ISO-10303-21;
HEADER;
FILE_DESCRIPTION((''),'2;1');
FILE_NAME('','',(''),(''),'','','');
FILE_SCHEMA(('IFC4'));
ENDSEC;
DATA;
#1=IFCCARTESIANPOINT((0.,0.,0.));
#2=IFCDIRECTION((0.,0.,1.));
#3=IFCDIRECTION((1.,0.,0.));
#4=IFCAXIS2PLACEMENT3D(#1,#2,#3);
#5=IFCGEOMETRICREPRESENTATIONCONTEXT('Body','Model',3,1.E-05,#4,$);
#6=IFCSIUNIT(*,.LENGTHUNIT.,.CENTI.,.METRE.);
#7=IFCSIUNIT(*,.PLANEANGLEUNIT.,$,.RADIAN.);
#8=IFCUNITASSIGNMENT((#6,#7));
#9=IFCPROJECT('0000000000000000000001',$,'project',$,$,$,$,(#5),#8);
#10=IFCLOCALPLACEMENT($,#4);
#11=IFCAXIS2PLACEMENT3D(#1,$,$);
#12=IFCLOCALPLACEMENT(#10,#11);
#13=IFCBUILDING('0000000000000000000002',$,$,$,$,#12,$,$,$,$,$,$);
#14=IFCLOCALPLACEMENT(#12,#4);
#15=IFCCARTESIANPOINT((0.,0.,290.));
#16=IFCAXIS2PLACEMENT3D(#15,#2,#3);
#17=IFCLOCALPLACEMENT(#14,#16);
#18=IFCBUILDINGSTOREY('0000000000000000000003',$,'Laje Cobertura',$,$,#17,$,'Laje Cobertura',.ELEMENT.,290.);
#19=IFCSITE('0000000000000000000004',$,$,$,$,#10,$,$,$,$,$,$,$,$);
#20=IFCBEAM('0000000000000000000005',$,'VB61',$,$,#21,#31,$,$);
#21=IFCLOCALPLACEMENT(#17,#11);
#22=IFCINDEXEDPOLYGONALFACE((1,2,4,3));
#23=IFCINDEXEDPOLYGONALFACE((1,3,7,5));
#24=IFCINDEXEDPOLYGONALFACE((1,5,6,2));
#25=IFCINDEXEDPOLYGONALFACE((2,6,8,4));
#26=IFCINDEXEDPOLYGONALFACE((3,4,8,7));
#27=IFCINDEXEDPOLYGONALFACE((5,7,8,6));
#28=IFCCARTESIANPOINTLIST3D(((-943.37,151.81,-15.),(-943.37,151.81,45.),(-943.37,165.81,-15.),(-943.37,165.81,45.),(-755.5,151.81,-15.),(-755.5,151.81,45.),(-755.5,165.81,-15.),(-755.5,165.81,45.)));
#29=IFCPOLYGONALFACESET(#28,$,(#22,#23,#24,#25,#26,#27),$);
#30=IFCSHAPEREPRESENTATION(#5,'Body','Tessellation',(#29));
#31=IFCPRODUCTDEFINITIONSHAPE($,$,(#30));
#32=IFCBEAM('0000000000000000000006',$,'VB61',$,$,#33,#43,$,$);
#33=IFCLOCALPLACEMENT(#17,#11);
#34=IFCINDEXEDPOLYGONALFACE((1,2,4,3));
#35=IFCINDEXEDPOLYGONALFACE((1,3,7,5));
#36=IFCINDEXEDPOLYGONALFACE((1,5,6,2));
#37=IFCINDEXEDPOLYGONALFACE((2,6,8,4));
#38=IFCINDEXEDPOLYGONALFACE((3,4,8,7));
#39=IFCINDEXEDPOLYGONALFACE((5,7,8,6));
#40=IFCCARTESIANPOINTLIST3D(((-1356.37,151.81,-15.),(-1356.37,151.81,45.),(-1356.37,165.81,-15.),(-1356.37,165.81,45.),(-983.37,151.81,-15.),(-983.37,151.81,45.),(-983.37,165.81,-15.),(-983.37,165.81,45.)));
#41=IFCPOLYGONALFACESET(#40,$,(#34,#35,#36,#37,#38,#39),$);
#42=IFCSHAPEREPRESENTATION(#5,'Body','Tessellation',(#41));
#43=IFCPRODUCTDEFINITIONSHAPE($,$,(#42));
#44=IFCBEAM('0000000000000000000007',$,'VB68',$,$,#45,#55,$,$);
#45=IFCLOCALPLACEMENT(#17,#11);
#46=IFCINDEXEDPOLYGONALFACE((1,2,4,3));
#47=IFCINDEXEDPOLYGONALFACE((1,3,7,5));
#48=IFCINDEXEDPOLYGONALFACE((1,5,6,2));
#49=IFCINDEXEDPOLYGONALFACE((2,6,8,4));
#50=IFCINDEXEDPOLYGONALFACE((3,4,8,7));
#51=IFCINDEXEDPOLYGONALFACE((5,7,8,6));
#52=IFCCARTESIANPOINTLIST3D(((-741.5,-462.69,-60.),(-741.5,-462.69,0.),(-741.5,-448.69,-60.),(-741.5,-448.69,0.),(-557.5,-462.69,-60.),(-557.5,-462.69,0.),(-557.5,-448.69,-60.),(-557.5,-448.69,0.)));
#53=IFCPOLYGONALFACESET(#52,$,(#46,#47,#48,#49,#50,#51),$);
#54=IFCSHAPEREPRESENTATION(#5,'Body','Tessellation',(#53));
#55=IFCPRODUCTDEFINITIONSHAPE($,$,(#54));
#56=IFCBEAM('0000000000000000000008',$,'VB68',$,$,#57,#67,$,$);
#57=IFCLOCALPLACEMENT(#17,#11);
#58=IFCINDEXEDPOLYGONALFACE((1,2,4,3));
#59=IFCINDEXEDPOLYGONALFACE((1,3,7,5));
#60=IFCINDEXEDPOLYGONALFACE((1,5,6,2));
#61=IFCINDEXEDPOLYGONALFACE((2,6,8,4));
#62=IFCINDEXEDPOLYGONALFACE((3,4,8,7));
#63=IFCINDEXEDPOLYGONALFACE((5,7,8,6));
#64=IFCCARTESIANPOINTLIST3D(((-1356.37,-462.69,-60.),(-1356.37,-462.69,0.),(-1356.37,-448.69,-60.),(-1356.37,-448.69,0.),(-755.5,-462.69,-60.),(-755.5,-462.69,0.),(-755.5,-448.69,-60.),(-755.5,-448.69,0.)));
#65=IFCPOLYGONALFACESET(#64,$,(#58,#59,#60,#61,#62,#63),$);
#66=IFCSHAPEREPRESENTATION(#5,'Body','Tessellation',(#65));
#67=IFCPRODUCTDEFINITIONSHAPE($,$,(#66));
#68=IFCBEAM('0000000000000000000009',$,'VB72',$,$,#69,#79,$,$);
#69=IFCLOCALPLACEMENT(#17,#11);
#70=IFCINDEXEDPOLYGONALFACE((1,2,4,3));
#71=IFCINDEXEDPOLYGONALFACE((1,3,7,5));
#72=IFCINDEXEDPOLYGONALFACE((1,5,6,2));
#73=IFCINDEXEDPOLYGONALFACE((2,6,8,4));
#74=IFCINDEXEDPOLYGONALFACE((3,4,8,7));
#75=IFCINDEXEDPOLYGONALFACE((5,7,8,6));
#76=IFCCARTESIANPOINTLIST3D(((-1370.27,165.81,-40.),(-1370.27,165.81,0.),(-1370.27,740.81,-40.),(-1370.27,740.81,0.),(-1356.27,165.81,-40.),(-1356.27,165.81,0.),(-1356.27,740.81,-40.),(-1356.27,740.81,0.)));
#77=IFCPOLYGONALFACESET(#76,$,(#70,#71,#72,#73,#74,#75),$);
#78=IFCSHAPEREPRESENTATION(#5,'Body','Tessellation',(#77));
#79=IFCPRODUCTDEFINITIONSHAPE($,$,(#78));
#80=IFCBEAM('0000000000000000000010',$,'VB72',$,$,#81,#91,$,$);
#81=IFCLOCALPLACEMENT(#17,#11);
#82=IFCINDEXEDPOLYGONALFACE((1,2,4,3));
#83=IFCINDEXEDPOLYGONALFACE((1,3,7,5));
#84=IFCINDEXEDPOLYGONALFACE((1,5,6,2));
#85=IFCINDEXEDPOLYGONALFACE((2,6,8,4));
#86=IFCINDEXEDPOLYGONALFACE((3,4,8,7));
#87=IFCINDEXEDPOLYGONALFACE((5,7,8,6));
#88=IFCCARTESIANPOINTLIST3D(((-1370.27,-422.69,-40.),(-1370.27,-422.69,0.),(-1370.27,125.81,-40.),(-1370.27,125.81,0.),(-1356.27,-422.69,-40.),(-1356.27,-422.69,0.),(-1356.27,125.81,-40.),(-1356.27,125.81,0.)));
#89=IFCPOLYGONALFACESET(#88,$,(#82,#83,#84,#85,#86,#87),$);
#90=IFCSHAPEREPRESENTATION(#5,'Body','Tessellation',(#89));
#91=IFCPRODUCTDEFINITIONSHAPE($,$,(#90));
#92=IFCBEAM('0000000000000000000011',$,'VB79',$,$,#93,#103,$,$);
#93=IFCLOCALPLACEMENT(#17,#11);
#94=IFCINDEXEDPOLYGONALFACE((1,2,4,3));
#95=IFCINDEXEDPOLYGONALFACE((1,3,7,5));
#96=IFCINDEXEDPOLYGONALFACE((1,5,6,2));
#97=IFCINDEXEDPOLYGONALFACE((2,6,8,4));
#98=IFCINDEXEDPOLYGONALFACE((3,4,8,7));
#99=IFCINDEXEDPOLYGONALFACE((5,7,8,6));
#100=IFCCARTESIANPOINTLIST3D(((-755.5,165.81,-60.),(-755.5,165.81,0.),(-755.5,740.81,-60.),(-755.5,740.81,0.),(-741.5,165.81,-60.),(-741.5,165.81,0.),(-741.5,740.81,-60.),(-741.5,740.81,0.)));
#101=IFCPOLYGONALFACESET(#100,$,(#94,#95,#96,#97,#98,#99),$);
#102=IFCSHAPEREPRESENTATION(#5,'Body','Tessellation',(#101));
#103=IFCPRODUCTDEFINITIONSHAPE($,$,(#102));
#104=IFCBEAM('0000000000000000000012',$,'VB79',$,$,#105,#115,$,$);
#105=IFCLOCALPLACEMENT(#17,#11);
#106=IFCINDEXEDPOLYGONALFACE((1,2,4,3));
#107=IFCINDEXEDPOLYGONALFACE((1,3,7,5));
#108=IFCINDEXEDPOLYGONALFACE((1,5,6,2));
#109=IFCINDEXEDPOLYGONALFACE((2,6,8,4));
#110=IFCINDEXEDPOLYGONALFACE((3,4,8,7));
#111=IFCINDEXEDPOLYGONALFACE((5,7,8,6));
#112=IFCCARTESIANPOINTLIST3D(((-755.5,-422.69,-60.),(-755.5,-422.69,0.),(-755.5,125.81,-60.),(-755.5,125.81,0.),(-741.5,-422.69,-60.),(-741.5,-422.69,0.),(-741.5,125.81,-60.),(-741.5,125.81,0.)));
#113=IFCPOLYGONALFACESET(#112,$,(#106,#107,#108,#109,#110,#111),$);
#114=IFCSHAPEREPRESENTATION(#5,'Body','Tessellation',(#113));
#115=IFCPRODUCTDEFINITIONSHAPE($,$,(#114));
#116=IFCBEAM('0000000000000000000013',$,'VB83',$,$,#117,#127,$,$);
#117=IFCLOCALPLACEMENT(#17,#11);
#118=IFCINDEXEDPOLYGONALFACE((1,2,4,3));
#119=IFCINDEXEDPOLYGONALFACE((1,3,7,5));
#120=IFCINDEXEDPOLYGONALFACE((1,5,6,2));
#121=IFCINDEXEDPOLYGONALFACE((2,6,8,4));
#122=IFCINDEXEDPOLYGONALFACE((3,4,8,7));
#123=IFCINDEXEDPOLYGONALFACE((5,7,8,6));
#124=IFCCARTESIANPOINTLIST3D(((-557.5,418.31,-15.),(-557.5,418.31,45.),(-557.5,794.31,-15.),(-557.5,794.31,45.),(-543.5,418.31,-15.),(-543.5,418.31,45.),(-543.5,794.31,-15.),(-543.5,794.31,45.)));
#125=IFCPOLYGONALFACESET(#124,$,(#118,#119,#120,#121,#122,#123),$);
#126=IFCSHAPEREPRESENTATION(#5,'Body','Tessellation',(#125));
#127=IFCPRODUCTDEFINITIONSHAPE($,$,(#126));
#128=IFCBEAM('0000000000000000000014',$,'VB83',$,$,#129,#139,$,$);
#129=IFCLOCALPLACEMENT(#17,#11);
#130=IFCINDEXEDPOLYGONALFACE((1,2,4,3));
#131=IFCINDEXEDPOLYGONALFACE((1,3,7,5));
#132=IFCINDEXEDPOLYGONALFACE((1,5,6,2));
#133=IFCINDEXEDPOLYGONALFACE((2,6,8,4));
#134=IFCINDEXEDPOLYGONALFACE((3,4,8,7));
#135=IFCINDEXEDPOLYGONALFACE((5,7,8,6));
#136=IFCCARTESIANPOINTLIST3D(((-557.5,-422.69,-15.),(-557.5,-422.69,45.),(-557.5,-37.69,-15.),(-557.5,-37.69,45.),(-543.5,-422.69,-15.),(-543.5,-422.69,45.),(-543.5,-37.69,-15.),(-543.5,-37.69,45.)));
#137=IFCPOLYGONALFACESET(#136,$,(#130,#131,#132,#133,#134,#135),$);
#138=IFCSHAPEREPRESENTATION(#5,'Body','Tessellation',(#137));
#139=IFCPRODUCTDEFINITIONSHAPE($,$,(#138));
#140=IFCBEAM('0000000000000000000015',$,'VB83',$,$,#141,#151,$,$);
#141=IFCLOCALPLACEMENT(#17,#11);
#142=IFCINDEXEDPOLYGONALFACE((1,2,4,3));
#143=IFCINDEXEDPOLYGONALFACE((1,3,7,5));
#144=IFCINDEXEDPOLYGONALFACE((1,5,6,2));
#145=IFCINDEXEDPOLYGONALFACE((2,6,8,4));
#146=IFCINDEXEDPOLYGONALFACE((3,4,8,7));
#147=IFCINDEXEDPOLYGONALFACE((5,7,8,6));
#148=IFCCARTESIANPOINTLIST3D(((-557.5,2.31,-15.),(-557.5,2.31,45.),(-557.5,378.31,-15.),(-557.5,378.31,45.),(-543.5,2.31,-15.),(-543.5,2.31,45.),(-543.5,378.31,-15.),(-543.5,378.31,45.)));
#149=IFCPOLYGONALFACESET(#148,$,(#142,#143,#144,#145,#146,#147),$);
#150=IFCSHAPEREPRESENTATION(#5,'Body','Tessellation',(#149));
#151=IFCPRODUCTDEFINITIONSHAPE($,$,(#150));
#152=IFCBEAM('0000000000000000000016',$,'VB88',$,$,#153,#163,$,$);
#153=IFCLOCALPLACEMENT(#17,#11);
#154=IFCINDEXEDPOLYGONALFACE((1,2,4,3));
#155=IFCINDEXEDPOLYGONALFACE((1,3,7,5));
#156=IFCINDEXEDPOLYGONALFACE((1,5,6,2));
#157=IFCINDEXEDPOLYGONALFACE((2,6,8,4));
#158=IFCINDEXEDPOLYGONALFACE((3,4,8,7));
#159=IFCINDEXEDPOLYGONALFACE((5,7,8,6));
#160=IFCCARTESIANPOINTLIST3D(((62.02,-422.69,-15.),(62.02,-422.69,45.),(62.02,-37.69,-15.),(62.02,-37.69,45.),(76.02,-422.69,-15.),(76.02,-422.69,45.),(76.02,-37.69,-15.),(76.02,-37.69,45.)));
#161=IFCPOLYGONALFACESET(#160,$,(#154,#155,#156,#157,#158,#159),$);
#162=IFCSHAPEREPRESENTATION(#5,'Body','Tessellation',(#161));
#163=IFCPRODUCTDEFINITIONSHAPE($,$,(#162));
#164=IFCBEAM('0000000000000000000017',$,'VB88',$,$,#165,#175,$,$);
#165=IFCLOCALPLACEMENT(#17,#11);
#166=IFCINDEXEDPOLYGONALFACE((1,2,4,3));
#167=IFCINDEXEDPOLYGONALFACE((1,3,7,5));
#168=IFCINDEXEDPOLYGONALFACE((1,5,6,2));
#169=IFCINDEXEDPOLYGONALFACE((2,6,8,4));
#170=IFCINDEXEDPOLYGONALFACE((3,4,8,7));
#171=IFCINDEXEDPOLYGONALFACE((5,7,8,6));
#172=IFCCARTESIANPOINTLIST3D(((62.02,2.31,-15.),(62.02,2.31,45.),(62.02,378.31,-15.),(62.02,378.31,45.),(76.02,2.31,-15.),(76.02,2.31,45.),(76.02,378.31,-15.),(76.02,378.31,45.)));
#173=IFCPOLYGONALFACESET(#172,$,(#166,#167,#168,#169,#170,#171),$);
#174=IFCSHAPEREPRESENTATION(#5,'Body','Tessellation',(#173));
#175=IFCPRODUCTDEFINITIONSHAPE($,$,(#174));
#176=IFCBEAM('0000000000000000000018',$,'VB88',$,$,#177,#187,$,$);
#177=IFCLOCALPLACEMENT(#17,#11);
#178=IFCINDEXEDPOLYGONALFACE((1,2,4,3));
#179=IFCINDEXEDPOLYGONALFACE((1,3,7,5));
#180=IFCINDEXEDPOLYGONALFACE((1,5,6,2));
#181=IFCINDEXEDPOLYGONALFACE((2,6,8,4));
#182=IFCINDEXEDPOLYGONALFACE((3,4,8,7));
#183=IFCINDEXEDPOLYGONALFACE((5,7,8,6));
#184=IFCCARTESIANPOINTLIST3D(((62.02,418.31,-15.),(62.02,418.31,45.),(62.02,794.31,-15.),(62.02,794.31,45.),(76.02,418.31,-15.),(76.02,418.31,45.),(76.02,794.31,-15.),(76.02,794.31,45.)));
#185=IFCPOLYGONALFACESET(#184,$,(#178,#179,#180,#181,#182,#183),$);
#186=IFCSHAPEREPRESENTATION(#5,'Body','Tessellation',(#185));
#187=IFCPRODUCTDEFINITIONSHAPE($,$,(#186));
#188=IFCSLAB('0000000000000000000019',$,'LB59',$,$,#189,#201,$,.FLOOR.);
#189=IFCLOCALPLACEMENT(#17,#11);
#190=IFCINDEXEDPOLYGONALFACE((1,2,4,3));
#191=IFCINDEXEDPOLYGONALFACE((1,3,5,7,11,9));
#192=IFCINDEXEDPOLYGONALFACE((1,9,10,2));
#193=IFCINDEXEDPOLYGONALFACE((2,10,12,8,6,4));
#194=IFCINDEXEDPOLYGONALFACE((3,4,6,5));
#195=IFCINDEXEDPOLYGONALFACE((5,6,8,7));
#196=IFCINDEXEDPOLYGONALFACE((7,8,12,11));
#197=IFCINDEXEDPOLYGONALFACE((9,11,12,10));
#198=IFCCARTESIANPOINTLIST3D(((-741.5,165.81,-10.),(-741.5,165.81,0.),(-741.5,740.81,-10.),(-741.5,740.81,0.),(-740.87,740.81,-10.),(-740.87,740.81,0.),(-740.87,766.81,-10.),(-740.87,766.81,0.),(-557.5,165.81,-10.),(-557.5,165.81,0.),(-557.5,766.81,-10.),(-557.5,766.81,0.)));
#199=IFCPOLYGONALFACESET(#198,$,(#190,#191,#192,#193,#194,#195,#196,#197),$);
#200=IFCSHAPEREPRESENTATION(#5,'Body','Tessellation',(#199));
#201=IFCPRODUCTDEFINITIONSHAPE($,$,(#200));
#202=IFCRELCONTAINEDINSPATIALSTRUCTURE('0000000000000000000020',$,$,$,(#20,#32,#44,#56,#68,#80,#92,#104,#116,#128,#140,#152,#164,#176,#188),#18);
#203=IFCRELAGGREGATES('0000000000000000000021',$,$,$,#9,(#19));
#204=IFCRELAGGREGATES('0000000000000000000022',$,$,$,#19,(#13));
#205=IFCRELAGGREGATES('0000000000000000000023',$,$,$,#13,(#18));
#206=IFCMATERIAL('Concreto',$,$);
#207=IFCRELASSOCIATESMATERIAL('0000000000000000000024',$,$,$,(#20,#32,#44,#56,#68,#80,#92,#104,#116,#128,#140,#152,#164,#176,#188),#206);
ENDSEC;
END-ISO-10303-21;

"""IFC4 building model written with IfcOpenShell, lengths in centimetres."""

from ifc_helpers import new_model, si_unit, frame, origin, origin_with_axes, origin_2d_with_axis, place, context, project, spatial, polyline, rectangle, outline, extrude, material, element, save


model = new_model("IFC4")

# Units and contexts
model_context = context("Model", 3, precision=1e-05, world=origin_with_axes(), identifier="Body")
ifc_project = project(units=[si_unit("LENGTHUNIT", "METRE", prefix="CENTI"), si_unit("PLANEANGLEUNIT", "RADIAN")], contexts=[model_context])

# Site, building, storey
site_placement = place(None, origin_with_axes())
site = spatial("IfcSite", under=ifc_project, at=site_placement)
building_placement = place(site_placement, origin())
building = spatial("IfcBuilding", under=site, at=building_placement)
placement = place(building_placement, origin_with_axes())
storey_placement = place(placement, frame((0.0, 0.0, 290.0), z_axis=(0.0, 0.0, 1.0), x_axis=(1.0, 0.0, 0.0)))
storey = spatial("IfcBuildingStorey", under=building, at=storey_placement, Name="Laje Cobertura", LongName="Laje Cobertura", CompositionType="ELEMENT", Elevation=290.0)

# Shared definitions
ifc_material = material(Name="Concreto")

# Beams
beam_1_placement = place(storey_placement, frame((-849.43, 158.81, 45.0), z_axis=(0.0, 0.0, 1.0), x_axis=(1.0, 0.0, 0.0)))
element("IfcBeam", 1, at=beam_1_placement, inside=storey, material=ifc_material, Name="VB61", context=model_context, shape_type="SolidModel", body=[
    extrude(rectangle(XDim=14.0, YDim=60.0, at=origin_2d_with_axis()), frame((-93.94, 0.0, -30.0), z_axis=(1.0, 0.0, 0.0), x_axis=(0.0, -1.0, 0.0)), (0.0, 0.0, 1.0), 187.87),
])
beam_2_placement = place(storey_placement, frame((-1169.87, 158.81, 45.0), z_axis=(0.0, 0.0, 1.0), x_axis=(1.0, 0.0, 0.0)))
element("IfcBeam", 2, at=beam_2_placement, inside=storey, material=ifc_material, Name="VB61", context=model_context, shape_type="SolidModel", body=[
    extrude(rectangle(XDim=14.0, YDim=60.0, at=origin_2d_with_axis()), frame((-186.5, 0.0, -30.0), z_axis=(1.0, 0.0, 0.0), x_axis=(0.0, -1.0, 0.0)), (0.0, 0.0, 1.0), 373.0),
])
beam_3_placement = place(storey_placement, frame((-649.5, -455.69, 0.0), z_axis=(0.0, 0.0, 1.0), x_axis=(1.0, 0.0, 0.0)))
element("IfcBeam", 3, at=beam_3_placement, inside=storey, material=ifc_material, Name="VB68", context=model_context, shape_type="SolidModel", body=[
    extrude(rectangle(XDim=14.0, YDim=60.0, at=origin_2d_with_axis()), frame((-92.0, 0.0, -30.0), z_axis=(1.0, 0.0, 0.0), x_axis=(0.0, -1.0, 0.0)), (0.0, 0.0, 1.0), 184.0),
])
beam_4_placement = place(storey_placement, frame((-1055.93, -455.69, 0.0), z_axis=(0.0, 0.0, 1.0), x_axis=(1.0, 0.0, 0.0)))
element("IfcBeam", 4, at=beam_4_placement, inside=storey, material=ifc_material, Name="VB68", context=model_context, shape_type="SolidModel", body=[
    extrude(rectangle(XDim=14.0, YDim=60.0, at=origin_2d_with_axis()), frame((-300.44, 0.0, -30.0), z_axis=(1.0, 0.0, 0.0), x_axis=(0.0, -1.0, 0.0)), (0.0, 0.0, 1.0), 600.87),
])
beam_5_placement = place(storey_placement, frame((-1363.27, 453.31, 0.0), z_axis=(0.0, 0.0, 1.0), x_axis=(1.0, 0.0, 0.0)))
element("IfcBeam", 5, at=beam_5_placement, inside=storey, material=ifc_material, Name="VB72", context=model_context, shape_type="SolidModel", body=[
    extrude(rectangle(XDim=14.0, YDim=40.0, at=origin_2d_with_axis()), frame((0.0, -287.5, -20.0), z_axis=(0.0, 1.0, 0.0), x_axis=(-1.0, 0.0, 0.0)), (0.0, 0.0, 1.0), 575.0),
])
beam_6_placement = place(storey_placement, frame((-1363.27, -148.44, 0.0), z_axis=(0.0, 0.0, 1.0), x_axis=(1.0, 0.0, 0.0)))
element("IfcBeam", 6, at=beam_6_placement, inside=storey, material=ifc_material, Name="VB72", context=model_context, shape_type="SolidModel", body=[
    extrude(rectangle(XDim=14.0, YDim=40.0, at=origin_2d_with_axis()), frame((0.0, -274.25, -20.0), z_axis=(0.0, 1.0, 0.0), x_axis=(-1.0, 0.0, 0.0)), (0.0, 0.0, 1.0), 548.5),
])
beam_7_placement = place(storey_placement, frame((-748.5, 453.31, 0.0), z_axis=(0.0, 0.0, 1.0), x_axis=(1.0, 0.0, 0.0)))
element("IfcBeam", 7, at=beam_7_placement, inside=storey, material=ifc_material, Name="VB79", context=model_context, shape_type="SolidModel", body=[
    extrude(rectangle(XDim=14.0, YDim=60.0, at=origin_2d_with_axis()), frame((0.0, -287.5, -30.0), z_axis=(0.0, 1.0, 0.0), x_axis=(-1.0, 0.0, 0.0)), (0.0, 0.0, 1.0), 575.0),
])
beam_8_placement = place(storey_placement, frame((-748.5, -148.44, 0.0), z_axis=(0.0, 0.0, 1.0), x_axis=(1.0, 0.0, 0.0)))
element("IfcBeam", 8, at=beam_8_placement, inside=storey, material=ifc_material, Name="VB79", context=model_context, shape_type="SolidModel", body=[
    extrude(rectangle(XDim=14.0, YDim=60.0, at=origin_2d_with_axis()), frame((0.0, -274.25, -30.0), z_axis=(0.0, 1.0, 0.0), x_axis=(-1.0, 0.0, 0.0)), (0.0, 0.0, 1.0), 548.5),
])
beam_9_placement = place(storey_placement, frame((-550.5, 606.31, 45.0), z_axis=(0.0, 0.0, 1.0), x_axis=(1.0, 0.0, 0.0)))
element("IfcBeam", 9, at=beam_9_placement, inside=storey, material=ifc_material, Name="VB83", context=model_context, shape_type="SolidModel", body=[
    extrude(rectangle(XDim=14.0, YDim=60.0, at=origin_2d_with_axis()), frame((0.0, -188.0, -30.0), z_axis=(0.0, 1.0, 0.0), x_axis=(-1.0, 0.0, 0.0)), (0.0, 0.0, 1.0), 376.0),
])
beam_10_placement = place(storey_placement, frame((-550.5, -230.19, 45.0), z_axis=(0.0, 0.0, 1.0), x_axis=(1.0, 0.0, 0.0)))
element("IfcBeam", 10, at=beam_10_placement, inside=storey, material=ifc_material, Name="VB83", context=model_context, shape_type="SolidModel", body=[
    extrude(rectangle(XDim=14.0, YDim=60.0, at=origin_2d_with_axis()), frame((0.0, -192.5, -30.0), z_axis=(0.0, 1.0, 0.0), x_axis=(-1.0, 0.0, 0.0)), (0.0, 0.0, 1.0), 385.0),
])
beam_11_placement = place(storey_placement, frame((-550.5, 190.31, 45.0), z_axis=(0.0, 0.0, 1.0), x_axis=(1.0, 0.0, 0.0)))
element("IfcBeam", 11, at=beam_11_placement, inside=storey, material=ifc_material, Name="VB83", context=model_context, shape_type="SolidModel", body=[
    extrude(rectangle(XDim=14.0, YDim=60.0, at=origin_2d_with_axis()), frame((0.0, -188.0, -30.0), z_axis=(0.0, 1.0, 0.0), x_axis=(-1.0, 0.0, 0.0)), (0.0, 0.0, 1.0), 376.0),
])
beam_12_placement = place(storey_placement, frame((69.02, -230.19, 45.0), z_axis=(0.0, 0.0, 1.0), x_axis=(1.0, 0.0, 0.0)))
element("IfcBeam", 12, at=beam_12_placement, inside=storey, material=ifc_material, Name="VB88", context=model_context, shape_type="SolidModel", body=[
    extrude(rectangle(XDim=14.0, YDim=60.0, at=origin_2d_with_axis()), frame((0.0, -192.5, -30.0), z_axis=(0.0, 1.0, 0.0), x_axis=(1.0, 0.0, 0.0)), (0.0, 0.0, 1.0), 385.0),
])
beam_13_placement = place(storey_placement, frame((69.02, 190.31, 45.0), z_axis=(0.0, 0.0, 1.0), x_axis=(1.0, 0.0, 0.0)))
element("IfcBeam", 13, at=beam_13_placement, inside=storey, material=ifc_material, Name="VB88", context=model_context, shape_type="SolidModel", body=[
    extrude(rectangle(XDim=14.0, YDim=60.0, at=origin_2d_with_axis()), frame((0.0, -188.0, -30.0), z_axis=(0.0, 1.0, 0.0), x_axis=(1.0, 0.0, 0.0)), (0.0, 0.0, 1.0), 376.0),
])
beam_14_placement = place(storey_placement, frame((69.02, 606.31, 45.0), z_axis=(0.0, 0.0, 1.0), x_axis=(1.0, 0.0, 0.0)))
element("IfcBeam", 14, at=beam_14_placement, inside=storey, material=ifc_material, Name="VB88", context=model_context, shape_type="SolidModel", body=[
    extrude(rectangle(XDim=14.0, YDim=60.0, at=origin_2d_with_axis()), frame((0.0, -188.0, -30.0), z_axis=(0.0, 1.0, 0.0), x_axis=(-1.0, 0.0, 0.0)), (0.0, 0.0, 1.0), 376.0),
])

# Slab
slab_1_placement = place(storey_placement, frame((-649.5, 466.31, 0.0), z_axis=(0.0, 0.0, 1.0), x_axis=(1.0, 0.0, 0.0)))
element("IfcSlab", 15, at=slab_1_placement, inside=storey, material=ifc_material, Name="LB59", PredefinedType="FLOOR", context=model_context, shape_type="SolidModel", body=[
    extrude(outline(polyline([(92.0, -300.5), (92.0, 300.5), (-91.37, 300.5), (-91.37, 274.5), (-92.0, 274.5), (-92.0, -300.5), (92.0, -300.5), (92.0, -300.5)])), frame((0.0, 0.0, -10.0), z_axis=(0.0, 0.0, 1.0), x_axis=(1.0, 0.0, 0.0)), (0.0, 0.0, 1.0), 10.0),
])

save(model, "model.ifc")
